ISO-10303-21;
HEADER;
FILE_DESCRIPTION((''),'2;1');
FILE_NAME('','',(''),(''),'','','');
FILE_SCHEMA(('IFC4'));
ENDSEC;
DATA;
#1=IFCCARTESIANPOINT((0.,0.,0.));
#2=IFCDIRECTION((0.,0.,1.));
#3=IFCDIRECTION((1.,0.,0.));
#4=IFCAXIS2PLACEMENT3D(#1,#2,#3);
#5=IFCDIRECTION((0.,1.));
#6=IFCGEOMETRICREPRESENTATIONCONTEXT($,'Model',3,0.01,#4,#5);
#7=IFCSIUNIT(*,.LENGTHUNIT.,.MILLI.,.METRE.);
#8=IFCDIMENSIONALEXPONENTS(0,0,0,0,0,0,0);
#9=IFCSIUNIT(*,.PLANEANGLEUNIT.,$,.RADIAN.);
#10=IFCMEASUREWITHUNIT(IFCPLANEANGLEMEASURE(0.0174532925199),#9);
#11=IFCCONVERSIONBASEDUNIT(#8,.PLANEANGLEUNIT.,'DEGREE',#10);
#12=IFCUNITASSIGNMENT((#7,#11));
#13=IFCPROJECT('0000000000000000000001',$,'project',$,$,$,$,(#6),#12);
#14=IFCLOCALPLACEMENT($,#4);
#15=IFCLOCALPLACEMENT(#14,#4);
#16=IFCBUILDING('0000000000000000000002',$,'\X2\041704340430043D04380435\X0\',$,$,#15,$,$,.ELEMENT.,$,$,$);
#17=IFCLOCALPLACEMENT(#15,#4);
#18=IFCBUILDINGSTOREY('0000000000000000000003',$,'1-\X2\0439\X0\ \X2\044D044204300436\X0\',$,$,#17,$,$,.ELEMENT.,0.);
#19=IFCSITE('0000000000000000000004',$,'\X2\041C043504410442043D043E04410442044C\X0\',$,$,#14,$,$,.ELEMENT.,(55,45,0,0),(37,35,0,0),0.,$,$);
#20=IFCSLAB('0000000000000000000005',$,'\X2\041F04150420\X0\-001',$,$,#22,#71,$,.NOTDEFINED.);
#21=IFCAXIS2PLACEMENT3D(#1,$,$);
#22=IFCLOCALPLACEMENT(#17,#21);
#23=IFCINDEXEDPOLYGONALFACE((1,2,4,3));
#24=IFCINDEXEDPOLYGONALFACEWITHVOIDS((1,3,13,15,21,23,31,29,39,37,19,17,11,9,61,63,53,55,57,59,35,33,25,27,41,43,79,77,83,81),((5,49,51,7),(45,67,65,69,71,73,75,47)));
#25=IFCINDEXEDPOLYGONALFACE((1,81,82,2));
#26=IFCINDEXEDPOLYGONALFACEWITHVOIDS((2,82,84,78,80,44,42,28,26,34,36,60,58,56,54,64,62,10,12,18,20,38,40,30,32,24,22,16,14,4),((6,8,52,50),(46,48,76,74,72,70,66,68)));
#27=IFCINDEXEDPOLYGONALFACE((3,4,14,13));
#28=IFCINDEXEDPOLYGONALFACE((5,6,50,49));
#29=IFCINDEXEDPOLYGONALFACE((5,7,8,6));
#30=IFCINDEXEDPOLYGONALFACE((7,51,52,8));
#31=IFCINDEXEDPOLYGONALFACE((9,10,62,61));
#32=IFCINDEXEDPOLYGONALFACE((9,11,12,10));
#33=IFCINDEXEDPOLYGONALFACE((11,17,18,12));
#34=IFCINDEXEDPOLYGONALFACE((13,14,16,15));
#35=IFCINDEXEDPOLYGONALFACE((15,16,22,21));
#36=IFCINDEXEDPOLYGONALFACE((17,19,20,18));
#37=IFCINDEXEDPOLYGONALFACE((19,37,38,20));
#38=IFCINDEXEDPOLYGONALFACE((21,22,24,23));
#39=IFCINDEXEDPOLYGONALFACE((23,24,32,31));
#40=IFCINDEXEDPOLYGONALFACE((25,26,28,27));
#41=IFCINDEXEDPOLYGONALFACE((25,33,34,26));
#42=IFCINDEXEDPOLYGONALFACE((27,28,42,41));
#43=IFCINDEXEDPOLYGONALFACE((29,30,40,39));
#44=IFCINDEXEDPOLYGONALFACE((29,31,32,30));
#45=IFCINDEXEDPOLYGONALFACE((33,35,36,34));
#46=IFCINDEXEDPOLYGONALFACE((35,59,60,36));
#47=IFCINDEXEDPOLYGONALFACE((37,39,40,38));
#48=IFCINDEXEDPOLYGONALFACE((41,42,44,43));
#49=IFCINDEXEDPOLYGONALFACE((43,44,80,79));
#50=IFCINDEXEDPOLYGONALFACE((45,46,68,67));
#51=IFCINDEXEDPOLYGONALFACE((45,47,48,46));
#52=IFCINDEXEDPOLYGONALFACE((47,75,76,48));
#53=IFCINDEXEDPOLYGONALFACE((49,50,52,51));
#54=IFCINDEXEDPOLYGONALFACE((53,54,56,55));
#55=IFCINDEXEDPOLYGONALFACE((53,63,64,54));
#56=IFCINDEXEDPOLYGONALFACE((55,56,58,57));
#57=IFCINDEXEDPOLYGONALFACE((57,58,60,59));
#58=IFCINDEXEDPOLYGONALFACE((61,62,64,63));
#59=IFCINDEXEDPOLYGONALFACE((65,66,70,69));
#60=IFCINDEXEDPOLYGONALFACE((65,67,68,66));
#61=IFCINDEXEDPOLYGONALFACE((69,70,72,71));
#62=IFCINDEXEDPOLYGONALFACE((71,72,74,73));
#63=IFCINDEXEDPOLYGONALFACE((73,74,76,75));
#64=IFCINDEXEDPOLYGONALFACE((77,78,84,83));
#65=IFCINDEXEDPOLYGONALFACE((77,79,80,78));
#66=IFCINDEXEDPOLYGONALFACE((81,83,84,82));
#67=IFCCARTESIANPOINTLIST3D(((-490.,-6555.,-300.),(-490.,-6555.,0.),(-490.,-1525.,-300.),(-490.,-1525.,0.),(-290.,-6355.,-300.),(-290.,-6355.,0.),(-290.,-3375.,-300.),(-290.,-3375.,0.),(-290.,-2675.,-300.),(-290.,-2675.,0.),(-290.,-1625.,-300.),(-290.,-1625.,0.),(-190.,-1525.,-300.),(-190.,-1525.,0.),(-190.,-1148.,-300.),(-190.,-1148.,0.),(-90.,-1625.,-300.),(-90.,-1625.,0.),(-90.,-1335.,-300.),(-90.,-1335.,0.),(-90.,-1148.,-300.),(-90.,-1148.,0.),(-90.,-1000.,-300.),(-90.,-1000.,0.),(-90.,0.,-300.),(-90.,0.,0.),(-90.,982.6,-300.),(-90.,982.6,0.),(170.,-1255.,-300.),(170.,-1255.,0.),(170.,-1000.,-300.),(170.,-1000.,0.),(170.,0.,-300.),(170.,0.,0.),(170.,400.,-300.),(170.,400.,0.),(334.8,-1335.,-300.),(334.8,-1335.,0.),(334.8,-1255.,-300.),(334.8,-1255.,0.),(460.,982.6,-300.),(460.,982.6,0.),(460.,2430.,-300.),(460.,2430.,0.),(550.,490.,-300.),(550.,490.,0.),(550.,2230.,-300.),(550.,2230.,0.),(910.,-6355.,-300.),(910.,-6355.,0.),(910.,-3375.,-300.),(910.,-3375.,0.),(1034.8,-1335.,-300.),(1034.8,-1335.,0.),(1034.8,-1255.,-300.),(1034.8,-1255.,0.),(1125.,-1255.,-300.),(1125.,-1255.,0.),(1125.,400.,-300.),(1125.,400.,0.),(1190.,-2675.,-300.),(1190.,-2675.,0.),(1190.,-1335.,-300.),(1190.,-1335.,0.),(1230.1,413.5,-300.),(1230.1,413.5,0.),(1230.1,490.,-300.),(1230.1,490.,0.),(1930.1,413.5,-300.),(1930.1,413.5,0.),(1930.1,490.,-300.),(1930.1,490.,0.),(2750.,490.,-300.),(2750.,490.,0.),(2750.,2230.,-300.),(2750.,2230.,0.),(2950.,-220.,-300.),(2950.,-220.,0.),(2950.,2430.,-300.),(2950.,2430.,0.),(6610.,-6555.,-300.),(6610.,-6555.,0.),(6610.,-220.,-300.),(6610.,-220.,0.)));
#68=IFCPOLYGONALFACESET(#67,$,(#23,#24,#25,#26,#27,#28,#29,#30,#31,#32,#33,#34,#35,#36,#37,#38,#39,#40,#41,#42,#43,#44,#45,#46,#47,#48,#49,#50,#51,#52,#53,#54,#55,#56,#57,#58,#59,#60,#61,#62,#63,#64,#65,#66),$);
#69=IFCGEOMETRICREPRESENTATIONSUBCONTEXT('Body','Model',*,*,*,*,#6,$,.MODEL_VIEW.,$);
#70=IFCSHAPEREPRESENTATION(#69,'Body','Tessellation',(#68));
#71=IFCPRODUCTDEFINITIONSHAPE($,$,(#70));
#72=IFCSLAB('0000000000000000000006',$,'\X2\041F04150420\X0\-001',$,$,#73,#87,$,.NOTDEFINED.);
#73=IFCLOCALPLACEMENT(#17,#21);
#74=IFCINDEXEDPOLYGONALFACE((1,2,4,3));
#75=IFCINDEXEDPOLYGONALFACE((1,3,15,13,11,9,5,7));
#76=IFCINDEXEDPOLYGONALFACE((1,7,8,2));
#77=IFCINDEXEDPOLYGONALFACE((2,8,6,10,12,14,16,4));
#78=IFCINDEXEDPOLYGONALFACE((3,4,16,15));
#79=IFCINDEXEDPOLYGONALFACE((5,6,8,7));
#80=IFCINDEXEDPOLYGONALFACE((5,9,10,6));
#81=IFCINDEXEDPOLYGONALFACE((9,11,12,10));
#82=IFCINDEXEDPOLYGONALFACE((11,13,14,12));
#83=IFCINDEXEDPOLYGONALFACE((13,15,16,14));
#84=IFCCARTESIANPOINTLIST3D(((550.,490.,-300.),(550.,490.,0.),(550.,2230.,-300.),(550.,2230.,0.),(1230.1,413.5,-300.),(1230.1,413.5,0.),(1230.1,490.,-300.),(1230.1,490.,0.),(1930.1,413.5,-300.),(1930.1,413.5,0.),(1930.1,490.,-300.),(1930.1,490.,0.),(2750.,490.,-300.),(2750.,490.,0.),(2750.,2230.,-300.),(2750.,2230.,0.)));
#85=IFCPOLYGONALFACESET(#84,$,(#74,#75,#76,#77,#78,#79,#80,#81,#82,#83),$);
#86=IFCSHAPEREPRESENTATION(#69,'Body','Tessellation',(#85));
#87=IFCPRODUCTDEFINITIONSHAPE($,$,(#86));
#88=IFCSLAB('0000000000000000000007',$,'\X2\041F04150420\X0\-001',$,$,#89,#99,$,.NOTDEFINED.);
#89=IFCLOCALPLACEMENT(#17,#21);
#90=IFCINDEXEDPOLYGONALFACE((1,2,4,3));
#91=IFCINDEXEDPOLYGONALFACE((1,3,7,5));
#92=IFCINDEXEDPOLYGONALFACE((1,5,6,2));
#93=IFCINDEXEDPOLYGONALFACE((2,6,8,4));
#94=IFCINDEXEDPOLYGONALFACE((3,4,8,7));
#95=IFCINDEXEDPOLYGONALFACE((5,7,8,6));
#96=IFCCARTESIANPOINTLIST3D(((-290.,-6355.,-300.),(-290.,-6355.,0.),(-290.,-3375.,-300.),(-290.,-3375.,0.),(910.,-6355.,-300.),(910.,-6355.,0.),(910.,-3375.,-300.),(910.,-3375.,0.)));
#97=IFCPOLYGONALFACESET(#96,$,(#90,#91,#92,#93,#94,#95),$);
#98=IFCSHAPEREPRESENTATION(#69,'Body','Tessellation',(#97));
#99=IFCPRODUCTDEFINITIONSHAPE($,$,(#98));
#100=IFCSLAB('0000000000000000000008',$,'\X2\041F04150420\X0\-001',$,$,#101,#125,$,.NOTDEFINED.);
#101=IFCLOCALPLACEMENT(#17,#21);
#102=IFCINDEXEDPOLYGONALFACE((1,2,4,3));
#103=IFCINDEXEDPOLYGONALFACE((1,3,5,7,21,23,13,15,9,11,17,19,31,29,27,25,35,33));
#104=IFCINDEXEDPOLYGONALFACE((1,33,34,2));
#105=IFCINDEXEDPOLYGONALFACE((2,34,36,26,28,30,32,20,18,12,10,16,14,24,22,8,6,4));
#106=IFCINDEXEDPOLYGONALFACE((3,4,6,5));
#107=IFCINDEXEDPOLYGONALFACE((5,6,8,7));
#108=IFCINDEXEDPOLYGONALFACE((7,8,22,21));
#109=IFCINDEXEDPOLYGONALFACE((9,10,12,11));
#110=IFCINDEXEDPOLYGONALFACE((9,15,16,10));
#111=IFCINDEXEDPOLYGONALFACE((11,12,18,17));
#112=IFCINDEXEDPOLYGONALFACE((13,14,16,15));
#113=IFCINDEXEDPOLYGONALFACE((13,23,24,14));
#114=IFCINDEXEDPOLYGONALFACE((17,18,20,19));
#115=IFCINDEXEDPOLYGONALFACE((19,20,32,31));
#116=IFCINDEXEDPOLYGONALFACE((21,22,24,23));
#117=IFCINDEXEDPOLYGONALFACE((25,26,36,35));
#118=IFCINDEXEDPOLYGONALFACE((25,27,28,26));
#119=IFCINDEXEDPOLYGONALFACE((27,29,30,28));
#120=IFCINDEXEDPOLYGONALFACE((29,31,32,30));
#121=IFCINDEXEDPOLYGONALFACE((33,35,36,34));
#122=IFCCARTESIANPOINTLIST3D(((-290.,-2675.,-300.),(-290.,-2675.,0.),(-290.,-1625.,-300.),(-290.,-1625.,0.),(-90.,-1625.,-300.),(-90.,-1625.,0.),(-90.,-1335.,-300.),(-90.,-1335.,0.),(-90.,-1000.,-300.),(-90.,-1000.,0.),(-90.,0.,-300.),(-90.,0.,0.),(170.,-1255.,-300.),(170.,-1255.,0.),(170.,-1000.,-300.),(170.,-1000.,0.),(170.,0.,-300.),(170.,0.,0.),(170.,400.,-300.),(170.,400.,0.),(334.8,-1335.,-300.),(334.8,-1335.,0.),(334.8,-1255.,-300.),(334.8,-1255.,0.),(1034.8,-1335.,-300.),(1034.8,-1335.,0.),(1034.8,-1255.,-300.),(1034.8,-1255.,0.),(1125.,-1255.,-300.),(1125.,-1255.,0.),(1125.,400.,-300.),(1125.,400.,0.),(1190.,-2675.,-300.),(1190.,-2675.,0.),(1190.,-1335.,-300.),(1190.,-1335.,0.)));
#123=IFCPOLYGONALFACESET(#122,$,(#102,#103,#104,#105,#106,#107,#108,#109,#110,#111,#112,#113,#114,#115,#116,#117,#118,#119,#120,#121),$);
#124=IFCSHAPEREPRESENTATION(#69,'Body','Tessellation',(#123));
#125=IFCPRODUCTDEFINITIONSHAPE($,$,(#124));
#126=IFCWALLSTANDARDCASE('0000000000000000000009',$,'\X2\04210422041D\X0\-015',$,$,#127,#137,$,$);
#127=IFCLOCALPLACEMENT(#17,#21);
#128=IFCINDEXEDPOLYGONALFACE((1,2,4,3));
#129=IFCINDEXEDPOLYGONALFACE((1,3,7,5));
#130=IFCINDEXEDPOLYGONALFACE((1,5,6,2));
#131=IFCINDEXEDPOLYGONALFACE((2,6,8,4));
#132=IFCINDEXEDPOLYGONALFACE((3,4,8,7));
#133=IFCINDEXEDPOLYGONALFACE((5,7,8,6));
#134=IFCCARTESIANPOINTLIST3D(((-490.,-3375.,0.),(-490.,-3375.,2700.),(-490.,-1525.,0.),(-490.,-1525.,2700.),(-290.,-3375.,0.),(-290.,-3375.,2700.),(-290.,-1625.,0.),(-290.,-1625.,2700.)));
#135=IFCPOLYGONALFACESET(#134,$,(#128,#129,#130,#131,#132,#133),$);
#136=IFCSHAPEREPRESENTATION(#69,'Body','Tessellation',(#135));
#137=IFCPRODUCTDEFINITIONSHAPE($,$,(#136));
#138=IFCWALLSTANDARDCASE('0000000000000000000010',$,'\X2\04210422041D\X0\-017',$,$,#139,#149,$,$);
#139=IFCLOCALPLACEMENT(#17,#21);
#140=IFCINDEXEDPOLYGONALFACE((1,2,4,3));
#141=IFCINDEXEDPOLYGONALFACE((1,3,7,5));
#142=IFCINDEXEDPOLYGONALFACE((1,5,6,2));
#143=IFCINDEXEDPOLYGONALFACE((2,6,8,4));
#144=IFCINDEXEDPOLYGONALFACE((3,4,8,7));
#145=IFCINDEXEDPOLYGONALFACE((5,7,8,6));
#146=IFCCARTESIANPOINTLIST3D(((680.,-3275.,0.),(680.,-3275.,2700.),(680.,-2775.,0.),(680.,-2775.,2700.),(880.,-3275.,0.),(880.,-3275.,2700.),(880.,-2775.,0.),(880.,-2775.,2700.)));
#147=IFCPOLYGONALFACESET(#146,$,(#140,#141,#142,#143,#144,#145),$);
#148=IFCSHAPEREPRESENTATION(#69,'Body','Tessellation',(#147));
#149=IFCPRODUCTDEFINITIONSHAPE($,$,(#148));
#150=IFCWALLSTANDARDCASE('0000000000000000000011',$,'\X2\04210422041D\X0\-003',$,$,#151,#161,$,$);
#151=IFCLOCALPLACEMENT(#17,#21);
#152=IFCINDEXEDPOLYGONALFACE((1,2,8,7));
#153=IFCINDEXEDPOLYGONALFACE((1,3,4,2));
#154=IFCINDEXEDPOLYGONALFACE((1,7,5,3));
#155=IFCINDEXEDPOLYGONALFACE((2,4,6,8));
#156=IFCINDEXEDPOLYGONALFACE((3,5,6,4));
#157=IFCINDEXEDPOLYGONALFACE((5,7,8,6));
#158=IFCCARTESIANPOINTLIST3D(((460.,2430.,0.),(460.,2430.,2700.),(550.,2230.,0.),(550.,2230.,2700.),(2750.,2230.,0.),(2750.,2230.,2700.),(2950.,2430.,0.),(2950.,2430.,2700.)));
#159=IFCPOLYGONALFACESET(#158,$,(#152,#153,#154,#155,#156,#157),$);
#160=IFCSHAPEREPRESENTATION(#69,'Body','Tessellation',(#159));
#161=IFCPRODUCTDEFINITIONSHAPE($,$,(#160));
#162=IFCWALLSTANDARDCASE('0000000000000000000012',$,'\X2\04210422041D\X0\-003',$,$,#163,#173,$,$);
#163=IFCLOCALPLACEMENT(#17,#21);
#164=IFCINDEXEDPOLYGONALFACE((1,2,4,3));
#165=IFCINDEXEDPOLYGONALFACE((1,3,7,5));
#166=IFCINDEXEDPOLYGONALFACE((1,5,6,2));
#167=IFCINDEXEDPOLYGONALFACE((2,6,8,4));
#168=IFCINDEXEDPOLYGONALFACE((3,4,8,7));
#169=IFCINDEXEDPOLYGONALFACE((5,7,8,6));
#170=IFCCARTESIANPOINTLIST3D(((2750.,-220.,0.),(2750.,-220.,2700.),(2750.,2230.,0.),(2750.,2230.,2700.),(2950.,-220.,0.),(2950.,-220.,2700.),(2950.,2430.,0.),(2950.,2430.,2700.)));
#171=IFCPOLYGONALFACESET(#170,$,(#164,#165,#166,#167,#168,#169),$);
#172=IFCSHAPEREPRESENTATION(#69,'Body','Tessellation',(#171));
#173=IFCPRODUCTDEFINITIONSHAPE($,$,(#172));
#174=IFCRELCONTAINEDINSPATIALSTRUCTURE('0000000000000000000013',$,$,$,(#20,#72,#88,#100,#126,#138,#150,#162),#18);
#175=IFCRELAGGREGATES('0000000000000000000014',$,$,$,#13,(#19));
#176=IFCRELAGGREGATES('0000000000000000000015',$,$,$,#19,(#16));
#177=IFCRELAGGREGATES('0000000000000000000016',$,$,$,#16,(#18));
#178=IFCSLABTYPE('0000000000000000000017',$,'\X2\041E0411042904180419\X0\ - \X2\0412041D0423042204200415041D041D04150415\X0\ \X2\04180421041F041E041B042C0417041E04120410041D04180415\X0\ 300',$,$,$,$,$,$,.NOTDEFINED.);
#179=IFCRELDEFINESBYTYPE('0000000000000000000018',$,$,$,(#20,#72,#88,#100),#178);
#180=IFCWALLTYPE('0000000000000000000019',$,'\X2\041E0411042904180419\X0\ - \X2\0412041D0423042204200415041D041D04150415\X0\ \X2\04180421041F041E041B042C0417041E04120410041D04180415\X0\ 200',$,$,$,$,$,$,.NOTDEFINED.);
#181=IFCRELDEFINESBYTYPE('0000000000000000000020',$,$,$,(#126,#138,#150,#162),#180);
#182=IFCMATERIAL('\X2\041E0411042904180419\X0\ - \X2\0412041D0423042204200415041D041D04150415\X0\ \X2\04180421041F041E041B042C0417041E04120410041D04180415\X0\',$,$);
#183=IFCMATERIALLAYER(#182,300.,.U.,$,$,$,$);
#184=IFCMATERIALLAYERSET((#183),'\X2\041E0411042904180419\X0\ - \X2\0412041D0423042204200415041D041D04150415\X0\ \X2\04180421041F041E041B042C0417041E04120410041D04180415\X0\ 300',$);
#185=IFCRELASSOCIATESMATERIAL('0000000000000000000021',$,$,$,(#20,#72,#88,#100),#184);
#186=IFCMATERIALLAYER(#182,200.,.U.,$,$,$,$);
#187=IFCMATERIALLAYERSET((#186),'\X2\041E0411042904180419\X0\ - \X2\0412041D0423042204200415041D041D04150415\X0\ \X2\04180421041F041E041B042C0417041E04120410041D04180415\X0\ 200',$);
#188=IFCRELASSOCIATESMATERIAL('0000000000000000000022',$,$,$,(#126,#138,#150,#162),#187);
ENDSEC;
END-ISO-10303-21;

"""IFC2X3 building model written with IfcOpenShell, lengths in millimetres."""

from ifc_helpers import new_model, entity, si_unit, converted_unit, direction, frame, origin_with_axes, place, context, subcontext, project, spatial, polyline, outline, extrude, material, layer, layer_set, layer_usage, type_object, element, save


model = new_model("IFC2X3")

# Units and contexts
model_context = context("Model", 3, precision=0.01, world=origin_with_axes(), true_north=direction((0.0, 1.0)))
body_context = subcontext(model_context, "Body", "Model", "MODEL_VIEW")
ifc_project = project(units=[si_unit("LENGTHUNIT", "METRE", prefix="MILLI"), converted_unit("PLANEANGLEUNIT", "DEGREE", entity("IfcPlaneAngleMeasure", 0.0174532925199), si_unit("PLANEANGLEUNIT", "RADIAN"), dimensions=[0, 0, 0, 0, 0, 0, 0])], contexts=[model_context])

# Site, building, storey
site_placement = place(None, origin_with_axes())
site = spatial("IfcSite", under=ifc_project, at=site_placement, Name="Местность", CompositionType="ELEMENT", RefLatitude=(55, 45, 0, 0), RefLongitude=(37, 35, 0, 0), RefElevation=0.0)
building_placement = place(site_placement, origin_with_axes())
building = spatial("IfcBuilding", under=site, at=building_placement, Name="Здание", CompositionType="ELEMENT")
storey_placement = place(building_placement, origin_with_axes())
storey = spatial("IfcBuildingStorey", under=building, at=storey_placement, Name="1-й этаж", CompositionType="ELEMENT", Elevation=0.0)

# Slabs
ifc_material = material(Name="ОБЩИЙ - ВНУТРЕННЕЕ ИСПОЛЬЗОВАНИЕ")
ifc_layer_1 = layer(ifc_material, 300.0, ventilated="UNKNOWN")
ifc_layer_set_1 = layer_set([ifc_layer_1], Name="ОБЩИЙ - ВНУТРЕННЕЕ ИСПОЛЬЗОВАНИЕ 300")
ifc_layer_usage_1 = layer_usage(ifc_layer_set_1, "AXIS3", "NEGATIVE", 300.0)
slab_type = type_object("IfcSlabType", Name="ОБЩИЙ - ВНУТРЕННЕЕ ИСПОЛЬЗОВАНИЕ 300", PredefinedType="NOTDEFINED")
slab_1_placement = place(storey_placement, frame((-490.0, -1525.0, 0.0), z_axis=(0.0, 0.0, 1.0), x_axis=(1.0, 0.0, 0.0)))
element("IfcSlab", 1, at=slab_1_placement, inside=storey, type_object=slab_type, material=ifc_layer_usage_1, Name="ПЕР-001", PredefinedType="NOTDEFINED", context=body_context, shape_type="SweptSolid", body=[
    extrude(outline(polyline([(0.0, 0.0), (0.0, -5030.0), (7100.0, -5030.0), (7100.0, 1305.0), (3440.0, 1305.0), (3440.0, 3955.0), (950.0, 3955.0), (950.0, 2507.6), (400.0, 2507.6), (400.0, 1525.0), (660.0, 1525.0), (660.0, 1925.0), (1615.0, 1925.0), (1615.0, 270.0), (1524.8, 270.0), (1524.8, 190.0), (1680.0, 190.0), (1680.0, -1150.0), (200.0, -1150.0), (200.0, -100.0), (400.0, -100.0), (400.0, 190.0), (824.8, 190.0), (824.8, 270.0), (660.0, 270.0), (660.0, 525.0), (400.0, 525.0), (400.0, 377.0), (300.0, 377.0), (300.0, 0.0), (0.0, 0.0)]), holes=[polyline([(1040.0, 3755.0), (3240.0, 3755.0), (3240.0, 2015.0), (2420.1, 2015.0), (2420.1, 1938.5), (1720.1, 1938.5), (1720.1, 2015.0), (1040.0, 2015.0), (1040.0, 3755.0)]), polyline([(1400.0, -1850.0), (1400.0, -4830.0), (200.0, -4830.0), (200.0, -1850.0), (1400.0, -1850.0)])]), frame((0.0, 0.0, -300.0), z_axis=(0.0, 0.0, 1.0), x_axis=(1.0, 0.0, 0.0)), (0.0, 0.0, 1.0), 300.0),
])
ifc_layer_usage_2 = layer_usage(ifc_layer_set_1, "AXIS3", "NEGATIVE", 300.0)
slab_2_placement = place(storey_placement, frame((550.0, 490.0, 0.0), z_axis=(0.0, 0.0, 1.0), x_axis=(1.0, 0.0, 0.0)))
element("IfcSlab", 2, at=slab_2_placement, inside=storey, type_object=slab_type, material=ifc_layer_usage_2, Name="ПЕР-001", PredefinedType="NOTDEFINED", context=body_context, shape_type="SweptSolid", body=[
    extrude(outline(polyline([(0.0, 0.0), (680.1, 0.0), (680.1, -76.5), (1380.1, -76.5), (1380.1, 0.0), (2200.0, 0.0), (2200.0, 1740.0), (0.0, 1740.0), (0.0, 0.0)])), frame((0.0, 0.0, -300.0), z_axis=(0.0, 0.0, 1.0), x_axis=(1.0, 0.0, 0.0)), (0.0, 0.0, 1.0), 300.0),
])
ifc_layer_usage_3 = layer_usage(ifc_layer_set_1, "AXIS3", "NEGATIVE", 300.0)
slab_3_placement = place(storey_placement, frame((-290.0, -6355.0, 0.0), z_axis=(0.0, 0.0, 1.0), x_axis=(1.0, 0.0, 0.0)))
element("IfcSlab", 3, at=slab_3_placement, inside=storey, type_object=slab_type, material=ifc_layer_usage_3, Name="ПЕР-001", PredefinedType="NOTDEFINED", context=body_context, shape_type="SweptSolid", body=[
    extrude(outline(polyline([(0.0, 0.0), (1200.0, 0.0), (1200.0, 2980.0), (0.0, 2980.0), (0.0, 0.0)])), frame((0.0, 0.0, -300.0), z_axis=(0.0, 0.0, 1.0), x_axis=(1.0, 0.0, 0.0)), (0.0, 0.0, 1.0), 300.0),
])
ifc_layer_usage_4 = layer_usage(ifc_layer_set_1, "AXIS3", "NEGATIVE", 300.0)
slab_4_placement = place(storey_placement, frame((1125.0, 400.0, 0.0), z_axis=(0.0, 0.0, 1.0), x_axis=(1.0, 0.0, 0.0)))
element("IfcSlab", 4, at=slab_4_placement, inside=storey, type_object=slab_type, material=ifc_layer_usage_4, Name="ПЕР-001", PredefinedType="NOTDEFINED", context=body_context, shape_type="SweptSolid", body=[
    extrude(outline(polyline([(0.0, 0.0), (-955.0, 0.0), (-955.0, -400.0), (-1215.0, -400.0), (-1215.0, -1400.0), (-955.0, -1400.0), (-955.0, -1655.0), (-790.2, -1655.0), (-790.2, -1735.0), (-1215.0, -1735.0), (-1215.0, -2025.0), (-1415.0, -2025.0), (-1415.0, -3075.0), (65.0, -3075.0), (65.0, -1735.0), (-90.2, -1735.0), (-90.2, -1655.0), (0.0, -1655.0), (0.0, 0.0)])), frame((0.0, 0.0, -300.0), z_axis=(0.0, 0.0, 1.0), x_axis=(1.0, 0.0, 0.0)), (0.0, 0.0, 1.0), 300.0),
])

# Walls
ifc_layer_2 = layer(ifc_material, 200.0, ventilated="UNKNOWN")
ifc_layer_set_2 = layer_set([ifc_layer_2], Name="ОБЩИЙ - ВНУТРЕННЕЕ ИСПОЛЬЗОВАНИЕ 200")
ifc_layer_usage_5 = layer_usage(ifc_layer_set_2, "AXIS2", "POSITIVE", 0.0)
wall_type_1 = type_object("IfcWallType", Name="ОБЩИЙ - ВНУТРЕННЕЕ ИСПОЛЬЗОВАНИЕ 200", PredefinedType="NOTDEFINED")
wall_1_placement = place(storey_placement, frame((-490.0, -1525.0, 0.0), z_axis=(0.0, 0.0, 1.0), x_axis=(0.0, -1.0, 0.0)))
element("IfcWallStandardCase", 5, at=wall_1_placement, inside=storey, type_object=wall_type_1, material=ifc_layer_usage_5, Name="СТН-015", context=body_context, shape_type="SweptSolid", body=[
    extrude(outline(polyline([(0.0, 0.0), (1850.0, 0.0), (1850.0, 200.0), (100.0, 200.0), (0.0, 0.0)])), origin_with_axes(), (0.0, 0.0, 1.0), 2700.0),
])
ifc_layer_usage_6 = layer_usage(ifc_layer_set_2, "AXIS2", "POSITIVE", -200.0)
wall_2_placement = place(storey_placement, frame((880.0, -2675.0, 0.0), z_axis=(0.0, 0.0, 1.0), x_axis=(0.0, -1.0, 0.0)))
element("IfcWallStandardCase", 6, at=wall_2_placement, inside=storey, type_object=wall_type_1, material=ifc_layer_usage_6, Name="СТН-017", context=body_context, shape_type="SweptSolid", body=[
    extrude(outline(polyline([(100.0, -200.0), (600.0, -200.0), (600.0, 0.0), (100.0, 0.0), (100.0, -200.0)])), origin_with_axes(), (0.0, 0.0, 1.0), 2700.0),
])
ifc_layer_usage_7 = layer_usage(ifc_layer_set_2, "AXIS2", "POSITIVE", -200.0)
wall_3_placement = place(storey_placement, frame((460.0, 2430.0, 0.0), z_axis=(0.0, 0.0, 1.0), x_axis=(1.0, 0.0, 0.0)))
element("IfcWallStandardCase", 7, at=wall_3_placement, inside=storey, type_object=wall_type_1, material=ifc_layer_usage_7, Name="СТН-003", context=body_context, shape_type="SweptSolid", body=[
    extrude(outline(polyline([(90.0, -200.0), (2290.0, -200.0), (2490.0, 0.0), (0.0, 0.0), (90.0, -200.0)])), origin_with_axes(), (0.0, 0.0, 1.0), 2700.0),
])
ifc_layer_usage_8 = layer_usage(ifc_layer_set_2, "AXIS2", "POSITIVE", -200.0)
wall_4_placement = place(storey_placement, frame((2950.0, 2430.0, 0.0), z_axis=(0.0, 0.0, 1.0), x_axis=(0.0, -1.0, 0.0)))
element("IfcWallStandardCase", 8, at=wall_4_placement, inside=storey, type_object=wall_type_1, material=ifc_layer_usage_8, Name="СТН-003", context=body_context, shape_type="SweptSolid", body=[
    extrude(outline(polyline([(200.0, -200.0), (2650.0, -200.0), (2650.0, 0.0), (0.0, 0.0), (200.0, -200.0)])), origin_with_axes(), (0.0, 0.0, 1.0), 2700.0),
])

save(model, "model.ifc")
